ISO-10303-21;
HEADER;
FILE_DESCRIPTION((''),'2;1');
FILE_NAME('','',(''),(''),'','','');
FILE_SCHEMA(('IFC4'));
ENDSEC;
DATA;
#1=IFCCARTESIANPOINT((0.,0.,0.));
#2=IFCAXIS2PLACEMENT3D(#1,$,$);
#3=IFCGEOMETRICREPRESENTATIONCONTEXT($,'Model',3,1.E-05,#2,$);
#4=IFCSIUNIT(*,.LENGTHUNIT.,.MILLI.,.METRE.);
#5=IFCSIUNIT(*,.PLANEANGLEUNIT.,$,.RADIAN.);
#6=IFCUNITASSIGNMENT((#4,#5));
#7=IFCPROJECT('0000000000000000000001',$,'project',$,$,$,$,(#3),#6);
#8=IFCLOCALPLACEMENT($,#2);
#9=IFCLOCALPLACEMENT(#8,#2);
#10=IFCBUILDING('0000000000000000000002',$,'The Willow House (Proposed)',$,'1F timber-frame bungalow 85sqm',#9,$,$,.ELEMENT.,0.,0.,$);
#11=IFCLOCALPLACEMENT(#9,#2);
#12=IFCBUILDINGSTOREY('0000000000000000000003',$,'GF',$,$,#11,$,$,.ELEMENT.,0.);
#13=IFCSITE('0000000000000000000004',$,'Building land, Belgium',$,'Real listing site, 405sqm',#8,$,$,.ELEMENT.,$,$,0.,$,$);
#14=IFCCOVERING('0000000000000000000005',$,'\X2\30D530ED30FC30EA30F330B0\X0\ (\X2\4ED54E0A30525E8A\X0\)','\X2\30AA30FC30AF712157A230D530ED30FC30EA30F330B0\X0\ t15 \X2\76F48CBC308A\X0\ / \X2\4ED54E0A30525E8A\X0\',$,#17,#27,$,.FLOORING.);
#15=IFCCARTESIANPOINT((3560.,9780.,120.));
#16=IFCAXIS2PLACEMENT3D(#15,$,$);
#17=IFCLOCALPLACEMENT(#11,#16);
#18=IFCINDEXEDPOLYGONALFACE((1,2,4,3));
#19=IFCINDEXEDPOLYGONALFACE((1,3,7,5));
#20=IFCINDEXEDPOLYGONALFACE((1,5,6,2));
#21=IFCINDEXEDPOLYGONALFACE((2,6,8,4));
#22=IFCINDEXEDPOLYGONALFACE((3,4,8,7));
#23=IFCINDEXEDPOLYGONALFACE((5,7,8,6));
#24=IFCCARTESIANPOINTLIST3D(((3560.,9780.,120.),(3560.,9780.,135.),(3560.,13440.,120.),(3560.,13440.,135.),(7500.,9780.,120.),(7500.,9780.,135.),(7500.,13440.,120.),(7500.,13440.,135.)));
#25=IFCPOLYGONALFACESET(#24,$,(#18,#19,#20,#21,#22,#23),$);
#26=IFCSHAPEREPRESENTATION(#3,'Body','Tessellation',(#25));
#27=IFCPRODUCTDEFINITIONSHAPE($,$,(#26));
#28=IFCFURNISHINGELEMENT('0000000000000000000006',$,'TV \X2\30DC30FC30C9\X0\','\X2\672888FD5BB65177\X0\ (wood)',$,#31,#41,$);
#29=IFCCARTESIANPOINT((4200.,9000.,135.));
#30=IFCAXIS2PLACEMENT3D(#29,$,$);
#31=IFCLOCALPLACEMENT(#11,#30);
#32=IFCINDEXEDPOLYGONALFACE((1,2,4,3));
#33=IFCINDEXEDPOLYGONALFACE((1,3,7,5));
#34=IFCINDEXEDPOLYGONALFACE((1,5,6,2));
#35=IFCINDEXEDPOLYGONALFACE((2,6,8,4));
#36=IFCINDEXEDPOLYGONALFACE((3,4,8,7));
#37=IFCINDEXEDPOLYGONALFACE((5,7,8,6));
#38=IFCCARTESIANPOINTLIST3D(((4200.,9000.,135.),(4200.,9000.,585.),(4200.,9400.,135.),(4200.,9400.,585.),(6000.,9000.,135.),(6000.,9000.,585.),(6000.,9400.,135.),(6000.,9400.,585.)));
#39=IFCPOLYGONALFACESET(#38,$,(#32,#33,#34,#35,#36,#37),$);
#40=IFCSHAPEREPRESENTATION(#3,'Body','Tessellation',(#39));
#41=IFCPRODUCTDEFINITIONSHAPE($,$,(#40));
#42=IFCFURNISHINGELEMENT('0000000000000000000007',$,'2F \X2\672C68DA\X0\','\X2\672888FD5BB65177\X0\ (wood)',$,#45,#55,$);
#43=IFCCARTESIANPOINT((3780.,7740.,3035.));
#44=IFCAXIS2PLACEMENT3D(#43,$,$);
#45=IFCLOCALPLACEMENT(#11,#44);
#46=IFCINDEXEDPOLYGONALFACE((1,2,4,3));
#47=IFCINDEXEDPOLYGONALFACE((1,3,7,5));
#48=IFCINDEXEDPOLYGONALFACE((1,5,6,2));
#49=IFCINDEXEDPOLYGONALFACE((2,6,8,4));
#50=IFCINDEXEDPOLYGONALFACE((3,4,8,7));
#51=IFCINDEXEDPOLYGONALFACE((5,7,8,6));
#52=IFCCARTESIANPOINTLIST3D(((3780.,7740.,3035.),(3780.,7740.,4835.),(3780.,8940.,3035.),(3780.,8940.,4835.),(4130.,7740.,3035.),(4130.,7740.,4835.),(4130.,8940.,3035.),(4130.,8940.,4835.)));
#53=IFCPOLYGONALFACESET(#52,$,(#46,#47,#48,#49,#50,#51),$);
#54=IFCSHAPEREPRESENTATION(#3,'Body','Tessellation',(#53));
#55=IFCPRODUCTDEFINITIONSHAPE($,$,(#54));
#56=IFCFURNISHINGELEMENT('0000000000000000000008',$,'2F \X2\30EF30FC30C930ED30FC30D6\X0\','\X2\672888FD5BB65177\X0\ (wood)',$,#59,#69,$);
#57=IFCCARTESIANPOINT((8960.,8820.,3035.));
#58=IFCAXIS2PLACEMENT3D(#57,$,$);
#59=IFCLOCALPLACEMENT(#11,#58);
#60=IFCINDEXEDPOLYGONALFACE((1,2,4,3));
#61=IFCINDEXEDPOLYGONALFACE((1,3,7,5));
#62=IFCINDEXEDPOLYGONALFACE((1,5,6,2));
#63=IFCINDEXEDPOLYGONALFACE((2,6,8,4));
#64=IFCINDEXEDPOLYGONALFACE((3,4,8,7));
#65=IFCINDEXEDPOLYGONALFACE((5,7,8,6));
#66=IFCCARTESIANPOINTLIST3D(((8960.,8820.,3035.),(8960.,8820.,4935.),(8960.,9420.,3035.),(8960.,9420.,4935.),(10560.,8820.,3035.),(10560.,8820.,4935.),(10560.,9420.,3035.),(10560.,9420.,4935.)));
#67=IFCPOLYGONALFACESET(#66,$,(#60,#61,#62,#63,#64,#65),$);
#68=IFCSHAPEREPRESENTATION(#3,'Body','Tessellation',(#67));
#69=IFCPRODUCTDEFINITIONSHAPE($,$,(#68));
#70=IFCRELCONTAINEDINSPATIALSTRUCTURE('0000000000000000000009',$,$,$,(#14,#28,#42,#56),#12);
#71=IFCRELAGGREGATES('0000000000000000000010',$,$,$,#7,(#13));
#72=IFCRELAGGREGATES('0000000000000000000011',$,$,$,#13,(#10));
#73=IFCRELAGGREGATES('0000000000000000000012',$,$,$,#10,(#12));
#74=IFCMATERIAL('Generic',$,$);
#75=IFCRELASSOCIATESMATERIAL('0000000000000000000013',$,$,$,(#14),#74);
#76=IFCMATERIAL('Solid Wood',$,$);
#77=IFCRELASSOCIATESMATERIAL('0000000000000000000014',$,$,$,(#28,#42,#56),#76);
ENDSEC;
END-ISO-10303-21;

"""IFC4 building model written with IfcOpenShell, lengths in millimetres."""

from ifc_helpers import new_model, si_unit, frame, frame_2d, origin, place, context, project, spatial, rectangle, extrude, material, element, save


model = new_model("IFC4")

# Units and contexts
model_context = context("Model", 3, precision=1e-05, world=origin())
ifc_project = project(units=[si_unit("LENGTHUNIT", "METRE", prefix="MILLI"), si_unit("PLANEANGLEUNIT", "RADIAN")], contexts=[model_context])

# Site, building, storey
site_placement = place(None, origin())
site = spatial("IfcSite", under=ifc_project, at=site_placement, Name="Building land, Belgium", ObjectType="Real listing site, 405sqm", CompositionType="ELEMENT", RefElevation=0.0)
building_placement = place(site_placement, origin())
building = spatial("IfcBuilding", under=site, at=building_placement, Name="The Willow House (Proposed)", ObjectType="1F timber-frame bungalow 85sqm", CompositionType="ELEMENT", ElevationOfRefHeight=0.0, ElevationOfTerrain=0.0)
storey_placement = place(building_placement, origin())
storey = spatial("IfcBuildingStorey", under=building, at=storey_placement, Name="GF", CompositionType="ELEMENT", Elevation=0.0)

# Shared definitions
ifc_material_1 = material(Name="Solid Wood")

# Shared definitions
ifc_material_2 = material(Name="Generic")

# Covering
covering_placement = place(storey_placement, frame((3560.0, 9780.0, 120.0)))
element("IfcCovering", 1, at=covering_placement, inside=storey, material=ifc_material_2, Name="フローリング (仕上げ床)", Description="オーク無垢フローリング t15 直貼り / 仕上げ床", PredefinedType="FLOORING", context=model_context, shape_type="SweptSolid", body=[
    extrude(rectangle(XDim=3940.0, YDim=3660.0, at=frame_2d((1970.0, 1830.0))), frame((3560.0, 9780.0, 120.0)), (0.0, 0.0, 1.0), 15.0),
])

# Furnishing elements
furnishing_1_placement = place(storey_placement, frame((4200.0, 9000.0, 135.0)))
element("IfcFurnishingElement", 2, at=furnishing_1_placement, inside=storey, material=ifc_material_1, Name="TV ボード", Description="木製家具 (wood)", context=model_context, shape_type="SweptSolid", body=[
    extrude(rectangle(XDim=1800.0, YDim=400.0, at=frame_2d((900.0, 200.0))), frame((4200.0, 9000.0, 135.0)), (0.0, 0.0, 1.0), 450.0),
])
furnishing_2_placement = place(storey_placement, frame((3780.0, 7740.0, 3035.0)))
element("IfcFurnishingElement", 3, at=furnishing_2_placement, inside=storey, material=ifc_material_1, Name="2F 本棚", Description="木製家具 (wood)", context=model_context, shape_type="SweptSolid", body=[
    extrude(rectangle(XDim=350.0, YDim=1200.0, at=frame_2d((175.0, 600.0))), frame((3780.0, 7740.0, 3035.0)), (0.0, 0.0, 1.0), 1800.0),
])
furnishing_3_placement = place(storey_placement, frame((8960.0, 8820.0, 3035.0)))
element("IfcFurnishingElement", 4, at=furnishing_3_placement, inside=storey, material=ifc_material_1, Name="2F ワードローブ", Description="木製家具 (wood)", context=model_context, shape_type="SweptSolid", body=[
    extrude(rectangle(XDim=1600.0, YDim=600.0, at=frame_2d((800.0, 300.0))), frame((8960.0, 8820.0, 3035.0)), (0.0, 0.0, 1.0), 1900.0),
])

save(model, "model.ifc")
